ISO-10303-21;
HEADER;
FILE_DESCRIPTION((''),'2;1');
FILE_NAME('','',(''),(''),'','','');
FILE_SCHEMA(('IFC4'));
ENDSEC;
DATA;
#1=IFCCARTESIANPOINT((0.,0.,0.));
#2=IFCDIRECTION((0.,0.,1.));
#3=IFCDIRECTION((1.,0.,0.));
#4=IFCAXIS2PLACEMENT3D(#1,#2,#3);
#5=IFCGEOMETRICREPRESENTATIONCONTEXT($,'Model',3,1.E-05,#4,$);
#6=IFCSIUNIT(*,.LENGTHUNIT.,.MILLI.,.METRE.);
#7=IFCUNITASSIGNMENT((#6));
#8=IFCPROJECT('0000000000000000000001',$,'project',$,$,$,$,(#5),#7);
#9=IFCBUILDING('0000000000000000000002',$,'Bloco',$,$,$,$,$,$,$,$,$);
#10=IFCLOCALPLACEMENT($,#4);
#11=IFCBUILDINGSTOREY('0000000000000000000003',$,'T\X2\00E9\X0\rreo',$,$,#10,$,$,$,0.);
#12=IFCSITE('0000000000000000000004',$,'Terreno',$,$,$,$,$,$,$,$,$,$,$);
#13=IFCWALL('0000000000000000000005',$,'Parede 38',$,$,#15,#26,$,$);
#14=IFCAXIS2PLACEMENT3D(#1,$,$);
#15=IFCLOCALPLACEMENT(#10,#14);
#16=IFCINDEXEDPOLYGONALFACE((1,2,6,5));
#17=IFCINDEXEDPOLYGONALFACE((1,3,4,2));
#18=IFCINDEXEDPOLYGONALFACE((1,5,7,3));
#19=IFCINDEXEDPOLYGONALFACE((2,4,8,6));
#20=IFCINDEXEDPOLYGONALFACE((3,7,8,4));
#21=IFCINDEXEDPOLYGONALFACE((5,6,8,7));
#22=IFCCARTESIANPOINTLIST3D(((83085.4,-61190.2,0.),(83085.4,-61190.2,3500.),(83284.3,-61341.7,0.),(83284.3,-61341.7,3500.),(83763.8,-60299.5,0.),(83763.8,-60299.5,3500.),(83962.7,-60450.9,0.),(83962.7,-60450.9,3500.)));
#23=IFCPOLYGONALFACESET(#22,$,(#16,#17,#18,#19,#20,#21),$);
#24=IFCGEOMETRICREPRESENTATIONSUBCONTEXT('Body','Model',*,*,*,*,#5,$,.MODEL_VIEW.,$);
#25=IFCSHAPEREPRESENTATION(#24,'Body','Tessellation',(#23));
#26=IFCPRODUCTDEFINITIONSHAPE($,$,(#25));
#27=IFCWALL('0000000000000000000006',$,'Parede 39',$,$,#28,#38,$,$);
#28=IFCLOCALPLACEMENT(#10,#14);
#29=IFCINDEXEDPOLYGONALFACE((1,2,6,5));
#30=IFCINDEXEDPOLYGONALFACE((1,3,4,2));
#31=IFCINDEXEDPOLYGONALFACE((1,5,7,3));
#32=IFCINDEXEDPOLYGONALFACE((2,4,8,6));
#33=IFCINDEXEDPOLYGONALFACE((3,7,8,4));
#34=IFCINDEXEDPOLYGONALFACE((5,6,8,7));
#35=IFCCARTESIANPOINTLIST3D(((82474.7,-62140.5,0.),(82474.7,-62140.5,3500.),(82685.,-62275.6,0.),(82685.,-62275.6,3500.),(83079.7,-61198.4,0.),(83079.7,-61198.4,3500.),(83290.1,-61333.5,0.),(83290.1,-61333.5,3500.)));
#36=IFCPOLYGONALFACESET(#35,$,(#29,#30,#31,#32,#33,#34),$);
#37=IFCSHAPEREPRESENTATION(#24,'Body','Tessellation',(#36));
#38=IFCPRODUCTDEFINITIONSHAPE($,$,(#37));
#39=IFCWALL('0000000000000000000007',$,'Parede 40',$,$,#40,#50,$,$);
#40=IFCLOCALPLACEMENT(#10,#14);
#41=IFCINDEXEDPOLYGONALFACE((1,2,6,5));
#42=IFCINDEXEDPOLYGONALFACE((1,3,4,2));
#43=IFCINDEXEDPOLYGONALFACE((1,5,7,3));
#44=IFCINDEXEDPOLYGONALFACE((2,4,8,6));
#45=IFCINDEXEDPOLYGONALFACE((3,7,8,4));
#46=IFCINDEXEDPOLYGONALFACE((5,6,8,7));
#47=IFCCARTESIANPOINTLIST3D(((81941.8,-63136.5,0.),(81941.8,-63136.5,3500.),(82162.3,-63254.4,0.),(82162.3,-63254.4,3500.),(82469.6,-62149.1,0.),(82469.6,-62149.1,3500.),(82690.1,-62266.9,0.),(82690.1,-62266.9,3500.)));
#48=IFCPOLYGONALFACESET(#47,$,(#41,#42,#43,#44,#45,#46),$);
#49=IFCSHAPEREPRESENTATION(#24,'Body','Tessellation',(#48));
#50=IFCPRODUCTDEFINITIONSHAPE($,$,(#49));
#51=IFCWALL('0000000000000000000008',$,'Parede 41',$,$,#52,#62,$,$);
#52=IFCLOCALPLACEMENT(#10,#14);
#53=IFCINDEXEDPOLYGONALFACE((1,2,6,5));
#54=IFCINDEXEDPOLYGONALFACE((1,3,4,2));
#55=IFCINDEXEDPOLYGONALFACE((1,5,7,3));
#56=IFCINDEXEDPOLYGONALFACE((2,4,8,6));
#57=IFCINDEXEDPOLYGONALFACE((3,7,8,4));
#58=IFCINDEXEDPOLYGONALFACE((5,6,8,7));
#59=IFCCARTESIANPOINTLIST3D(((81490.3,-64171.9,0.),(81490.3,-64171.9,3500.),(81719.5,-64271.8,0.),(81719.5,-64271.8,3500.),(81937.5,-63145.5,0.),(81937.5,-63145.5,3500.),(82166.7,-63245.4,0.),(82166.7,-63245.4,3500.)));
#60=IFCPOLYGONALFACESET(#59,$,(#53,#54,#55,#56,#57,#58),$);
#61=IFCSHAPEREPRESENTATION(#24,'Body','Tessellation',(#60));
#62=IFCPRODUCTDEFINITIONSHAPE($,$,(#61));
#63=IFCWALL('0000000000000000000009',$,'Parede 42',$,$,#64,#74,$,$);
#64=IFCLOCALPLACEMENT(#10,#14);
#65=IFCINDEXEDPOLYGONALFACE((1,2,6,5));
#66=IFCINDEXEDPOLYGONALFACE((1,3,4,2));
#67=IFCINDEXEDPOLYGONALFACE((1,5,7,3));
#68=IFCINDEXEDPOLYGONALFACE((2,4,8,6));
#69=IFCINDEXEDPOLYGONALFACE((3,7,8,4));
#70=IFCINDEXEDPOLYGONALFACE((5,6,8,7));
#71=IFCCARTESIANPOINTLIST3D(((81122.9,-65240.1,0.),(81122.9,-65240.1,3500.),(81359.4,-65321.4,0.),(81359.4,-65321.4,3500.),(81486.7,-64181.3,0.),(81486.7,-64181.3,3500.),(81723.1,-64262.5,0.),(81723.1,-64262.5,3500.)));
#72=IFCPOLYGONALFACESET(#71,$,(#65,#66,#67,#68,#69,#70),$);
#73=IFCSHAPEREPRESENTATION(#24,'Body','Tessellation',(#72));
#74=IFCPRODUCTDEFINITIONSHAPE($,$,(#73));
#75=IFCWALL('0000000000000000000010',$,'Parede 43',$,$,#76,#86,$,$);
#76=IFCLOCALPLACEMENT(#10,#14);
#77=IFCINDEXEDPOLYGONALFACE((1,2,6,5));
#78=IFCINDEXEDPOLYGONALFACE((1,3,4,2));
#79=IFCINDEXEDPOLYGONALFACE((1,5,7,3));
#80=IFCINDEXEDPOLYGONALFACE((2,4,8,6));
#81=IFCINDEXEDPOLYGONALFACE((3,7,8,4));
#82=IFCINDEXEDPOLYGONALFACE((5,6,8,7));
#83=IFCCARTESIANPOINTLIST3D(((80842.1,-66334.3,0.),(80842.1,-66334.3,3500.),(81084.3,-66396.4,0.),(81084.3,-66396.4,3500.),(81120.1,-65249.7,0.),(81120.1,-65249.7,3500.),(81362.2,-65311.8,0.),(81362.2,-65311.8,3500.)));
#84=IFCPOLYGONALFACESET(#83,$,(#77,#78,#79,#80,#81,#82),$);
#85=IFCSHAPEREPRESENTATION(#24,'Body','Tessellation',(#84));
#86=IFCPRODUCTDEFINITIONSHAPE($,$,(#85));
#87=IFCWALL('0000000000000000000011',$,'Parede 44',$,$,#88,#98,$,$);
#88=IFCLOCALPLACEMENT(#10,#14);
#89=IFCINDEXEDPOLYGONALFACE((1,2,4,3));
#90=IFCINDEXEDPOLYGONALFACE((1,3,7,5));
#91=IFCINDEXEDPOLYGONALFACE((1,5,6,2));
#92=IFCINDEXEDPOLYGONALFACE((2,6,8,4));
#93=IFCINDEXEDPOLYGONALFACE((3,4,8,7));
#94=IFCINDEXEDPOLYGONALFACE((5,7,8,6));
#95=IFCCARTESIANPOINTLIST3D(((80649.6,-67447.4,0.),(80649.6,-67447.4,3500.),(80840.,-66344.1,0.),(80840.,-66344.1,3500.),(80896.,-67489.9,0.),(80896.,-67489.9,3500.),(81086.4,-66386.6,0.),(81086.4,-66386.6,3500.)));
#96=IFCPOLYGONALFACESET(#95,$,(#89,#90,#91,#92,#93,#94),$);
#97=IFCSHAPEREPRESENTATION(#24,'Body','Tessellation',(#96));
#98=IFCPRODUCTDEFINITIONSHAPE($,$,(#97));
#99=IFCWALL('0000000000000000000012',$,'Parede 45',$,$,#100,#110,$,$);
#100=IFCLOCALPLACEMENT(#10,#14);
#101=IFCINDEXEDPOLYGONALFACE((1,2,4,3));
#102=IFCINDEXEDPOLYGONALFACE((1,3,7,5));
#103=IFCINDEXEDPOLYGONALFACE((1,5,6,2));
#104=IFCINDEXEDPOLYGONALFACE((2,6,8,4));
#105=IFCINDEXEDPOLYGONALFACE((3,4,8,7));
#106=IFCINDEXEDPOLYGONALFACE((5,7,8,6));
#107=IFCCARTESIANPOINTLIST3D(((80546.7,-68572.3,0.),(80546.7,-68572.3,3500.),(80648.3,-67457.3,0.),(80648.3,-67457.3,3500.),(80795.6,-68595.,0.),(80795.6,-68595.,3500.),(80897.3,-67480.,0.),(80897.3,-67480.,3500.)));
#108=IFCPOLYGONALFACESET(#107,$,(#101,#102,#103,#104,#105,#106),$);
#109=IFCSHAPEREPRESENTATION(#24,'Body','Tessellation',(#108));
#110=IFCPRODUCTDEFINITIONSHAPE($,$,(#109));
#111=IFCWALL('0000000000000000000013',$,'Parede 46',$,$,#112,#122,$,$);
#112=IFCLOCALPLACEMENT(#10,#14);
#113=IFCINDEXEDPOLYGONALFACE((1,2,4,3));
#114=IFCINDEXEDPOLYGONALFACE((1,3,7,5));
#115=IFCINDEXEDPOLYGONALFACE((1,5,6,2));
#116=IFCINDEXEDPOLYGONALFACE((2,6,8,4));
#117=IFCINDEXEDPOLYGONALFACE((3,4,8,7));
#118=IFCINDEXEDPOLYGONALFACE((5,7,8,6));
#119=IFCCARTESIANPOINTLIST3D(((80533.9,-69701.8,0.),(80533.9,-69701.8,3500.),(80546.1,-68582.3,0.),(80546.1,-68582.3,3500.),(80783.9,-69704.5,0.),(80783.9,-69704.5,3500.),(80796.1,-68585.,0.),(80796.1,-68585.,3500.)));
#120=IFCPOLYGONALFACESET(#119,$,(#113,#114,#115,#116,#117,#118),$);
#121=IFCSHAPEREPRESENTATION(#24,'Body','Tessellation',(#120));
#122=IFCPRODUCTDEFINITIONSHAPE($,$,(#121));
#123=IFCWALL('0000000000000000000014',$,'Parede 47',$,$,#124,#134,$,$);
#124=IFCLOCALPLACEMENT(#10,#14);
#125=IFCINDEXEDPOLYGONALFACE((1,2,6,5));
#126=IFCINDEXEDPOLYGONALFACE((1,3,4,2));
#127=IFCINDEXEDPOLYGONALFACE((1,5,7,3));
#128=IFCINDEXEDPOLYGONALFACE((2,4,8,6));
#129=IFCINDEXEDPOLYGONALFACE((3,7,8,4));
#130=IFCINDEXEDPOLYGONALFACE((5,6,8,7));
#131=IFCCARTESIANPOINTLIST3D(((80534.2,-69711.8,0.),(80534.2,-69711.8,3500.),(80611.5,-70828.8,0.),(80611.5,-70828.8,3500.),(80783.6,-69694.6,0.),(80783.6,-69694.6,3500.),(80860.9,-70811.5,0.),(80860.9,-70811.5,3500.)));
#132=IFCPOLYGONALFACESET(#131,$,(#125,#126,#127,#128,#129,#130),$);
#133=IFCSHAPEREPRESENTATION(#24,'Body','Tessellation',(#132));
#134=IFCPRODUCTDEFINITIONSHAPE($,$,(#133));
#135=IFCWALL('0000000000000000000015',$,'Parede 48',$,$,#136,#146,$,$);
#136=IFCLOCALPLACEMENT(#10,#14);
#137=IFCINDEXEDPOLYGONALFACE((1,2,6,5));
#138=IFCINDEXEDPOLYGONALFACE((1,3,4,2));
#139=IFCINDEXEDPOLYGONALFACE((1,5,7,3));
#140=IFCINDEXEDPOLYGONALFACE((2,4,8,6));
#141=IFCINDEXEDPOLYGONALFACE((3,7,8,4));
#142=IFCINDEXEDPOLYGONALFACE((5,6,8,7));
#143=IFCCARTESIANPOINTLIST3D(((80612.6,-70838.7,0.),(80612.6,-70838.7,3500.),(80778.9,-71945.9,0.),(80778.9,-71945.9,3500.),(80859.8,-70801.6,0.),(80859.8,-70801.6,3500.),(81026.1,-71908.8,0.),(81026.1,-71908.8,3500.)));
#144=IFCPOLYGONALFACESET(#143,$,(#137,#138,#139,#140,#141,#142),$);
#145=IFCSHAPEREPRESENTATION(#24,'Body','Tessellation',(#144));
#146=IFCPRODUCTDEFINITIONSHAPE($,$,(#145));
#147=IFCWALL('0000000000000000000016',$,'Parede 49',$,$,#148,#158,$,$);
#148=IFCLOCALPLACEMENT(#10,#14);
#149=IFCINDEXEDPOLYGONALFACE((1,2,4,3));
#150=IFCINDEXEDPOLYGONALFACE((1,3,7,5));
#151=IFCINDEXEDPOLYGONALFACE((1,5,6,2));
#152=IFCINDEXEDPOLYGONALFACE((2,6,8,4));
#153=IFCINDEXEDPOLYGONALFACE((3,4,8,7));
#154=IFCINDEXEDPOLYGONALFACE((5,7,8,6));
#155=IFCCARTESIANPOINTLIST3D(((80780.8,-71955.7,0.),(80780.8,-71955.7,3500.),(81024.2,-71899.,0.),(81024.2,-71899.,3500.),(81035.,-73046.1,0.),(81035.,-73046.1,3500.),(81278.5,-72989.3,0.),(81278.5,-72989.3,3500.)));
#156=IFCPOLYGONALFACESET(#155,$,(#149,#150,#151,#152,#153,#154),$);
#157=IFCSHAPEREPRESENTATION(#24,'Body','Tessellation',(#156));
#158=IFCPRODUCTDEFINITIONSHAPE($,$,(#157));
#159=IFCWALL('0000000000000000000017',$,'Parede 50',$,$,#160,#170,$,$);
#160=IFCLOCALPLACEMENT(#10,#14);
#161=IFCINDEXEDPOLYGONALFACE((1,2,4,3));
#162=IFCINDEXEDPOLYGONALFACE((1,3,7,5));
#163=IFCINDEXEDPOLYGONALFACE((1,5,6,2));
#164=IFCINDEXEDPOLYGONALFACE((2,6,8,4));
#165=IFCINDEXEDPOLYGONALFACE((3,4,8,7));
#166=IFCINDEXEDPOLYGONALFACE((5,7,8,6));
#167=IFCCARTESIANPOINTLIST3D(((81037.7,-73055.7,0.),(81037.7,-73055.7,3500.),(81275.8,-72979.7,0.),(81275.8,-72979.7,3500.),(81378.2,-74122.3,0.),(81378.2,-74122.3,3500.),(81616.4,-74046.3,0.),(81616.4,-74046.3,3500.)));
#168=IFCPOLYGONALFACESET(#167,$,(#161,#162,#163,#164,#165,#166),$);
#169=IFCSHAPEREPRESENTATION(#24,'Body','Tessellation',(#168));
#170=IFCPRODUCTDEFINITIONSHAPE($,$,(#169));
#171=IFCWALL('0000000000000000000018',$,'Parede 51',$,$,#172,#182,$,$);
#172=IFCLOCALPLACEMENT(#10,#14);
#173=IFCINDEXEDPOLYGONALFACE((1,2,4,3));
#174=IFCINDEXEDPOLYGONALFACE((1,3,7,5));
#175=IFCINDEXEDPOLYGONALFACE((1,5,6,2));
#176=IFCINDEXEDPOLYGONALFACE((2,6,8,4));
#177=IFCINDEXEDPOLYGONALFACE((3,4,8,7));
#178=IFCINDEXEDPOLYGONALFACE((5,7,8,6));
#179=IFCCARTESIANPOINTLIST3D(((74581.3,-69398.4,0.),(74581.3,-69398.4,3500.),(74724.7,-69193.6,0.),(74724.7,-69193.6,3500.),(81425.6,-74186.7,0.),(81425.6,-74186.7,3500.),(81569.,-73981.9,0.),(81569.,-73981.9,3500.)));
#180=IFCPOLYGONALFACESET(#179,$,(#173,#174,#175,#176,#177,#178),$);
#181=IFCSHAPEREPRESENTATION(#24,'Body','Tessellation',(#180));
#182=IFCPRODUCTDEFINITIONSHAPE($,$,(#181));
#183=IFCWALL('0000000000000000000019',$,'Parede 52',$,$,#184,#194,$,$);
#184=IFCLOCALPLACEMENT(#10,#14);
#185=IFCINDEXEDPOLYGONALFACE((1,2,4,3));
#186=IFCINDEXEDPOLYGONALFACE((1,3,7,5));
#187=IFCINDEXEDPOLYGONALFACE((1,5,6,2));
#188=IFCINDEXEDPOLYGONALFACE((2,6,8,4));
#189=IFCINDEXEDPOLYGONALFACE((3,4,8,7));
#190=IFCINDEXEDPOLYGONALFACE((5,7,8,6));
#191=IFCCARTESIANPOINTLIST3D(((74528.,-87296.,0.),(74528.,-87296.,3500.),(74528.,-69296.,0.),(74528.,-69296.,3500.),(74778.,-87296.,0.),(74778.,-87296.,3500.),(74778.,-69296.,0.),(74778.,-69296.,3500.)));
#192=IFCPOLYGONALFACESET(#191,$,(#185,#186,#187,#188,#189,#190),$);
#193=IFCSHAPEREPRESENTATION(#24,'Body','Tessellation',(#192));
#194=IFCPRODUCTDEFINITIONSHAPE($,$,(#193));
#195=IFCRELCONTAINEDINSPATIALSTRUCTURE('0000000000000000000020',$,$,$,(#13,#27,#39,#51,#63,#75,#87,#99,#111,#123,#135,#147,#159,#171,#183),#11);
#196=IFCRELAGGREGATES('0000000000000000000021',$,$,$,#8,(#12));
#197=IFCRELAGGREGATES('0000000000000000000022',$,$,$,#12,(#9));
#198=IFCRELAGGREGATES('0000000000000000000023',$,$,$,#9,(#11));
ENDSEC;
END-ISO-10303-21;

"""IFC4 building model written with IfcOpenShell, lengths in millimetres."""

from ifc_helpers import new_model, si_unit, origin, origin_with_axes, place, context, subcontext, project, spatial, polyline, outline, extrude, element, save


model = new_model("IFC4")

# Units and contexts
model_context = context("Model", 3, precision=1e-05, world=origin_with_axes())
body_context = subcontext(model_context, "Body", "Model", "MODEL_VIEW")
ifc_project = project(units=[si_unit("LENGTHUNIT", "METRE", prefix="MILLI")], contexts=[model_context])

# Site, building, storey
site = spatial("IfcSite", under=ifc_project, Name="Terreno")
building = spatial("IfcBuilding", under=site, Name="Bloco")
storey_placement = place(None, origin_with_axes())
storey = spatial("IfcBuildingStorey", under=building, at=storey_placement, Name="Térreo", Elevation=0.0)

# Walls
wall_1_placement = place(storey_placement, origin_with_axes())
element("IfcWall", 1, at=wall_1_placement, inside=storey, Name="Parede 38", context=body_context, shape_type="SweptSolid", body=[
    extrude(outline(polyline([(83962.7, -60450.9), (83284.3, -61341.7), (83085.4, -61190.2), (83763.8, -60299.5), (83962.7, -60450.9)])), origin(), (0.0, 0.0, 1.0), 3500.0),
])
wall_2_placement = place(storey_placement, origin_with_axes())
element("IfcWall", 2, at=wall_2_placement, inside=storey, Name="Parede 39", context=body_context, shape_type="SweptSolid", body=[
    extrude(outline(polyline([(83290.1, -61333.5), (82685.0, -62275.6), (82474.7, -62140.5), (83079.7, -61198.4), (83290.1, -61333.5)])), origin(), (0.0, 0.0, 1.0), 3500.0),
])
wall_3_placement = place(storey_placement, origin_with_axes())
element("IfcWall", 3, at=wall_3_placement, inside=storey, Name="Parede 40", context=body_context, shape_type="SweptSolid", body=[
    extrude(outline(polyline([(82690.1, -62266.9), (82162.3, -63254.4), (81941.8, -63136.5), (82469.6, -62149.1), (82690.1, -62266.9)])), origin(), (0.0, 0.0, 1.0), 3500.0),
])
wall_4_placement = place(storey_placement, origin_with_axes())
element("IfcWall", 4, at=wall_4_placement, inside=storey, Name="Parede 41", context=body_context, shape_type="SweptSolid", body=[
    extrude(outline(polyline([(82166.7, -63245.4), (81719.5, -64271.8), (81490.3, -64171.9), (81937.5, -63145.5), (82166.7, -63245.4)])), origin(), (0.0, 0.0, 1.0), 3500.0),
])
wall_5_placement = place(storey_placement, origin_with_axes())
element("IfcWall", 5, at=wall_5_placement, inside=storey, Name="Parede 42", context=body_context, shape_type="SweptSolid", body=[
    extrude(outline(polyline([(81723.1, -64262.5), (81359.4, -65321.4), (81122.9, -65240.1), (81486.7, -64181.3), (81723.1, -64262.5)])), origin(), (0.0, 0.0, 1.0), 3500.0),
])
wall_6_placement = place(storey_placement, origin_with_axes())
element("IfcWall", 6, at=wall_6_placement, inside=storey, Name="Parede 43", context=body_context, shape_type="SweptSolid", body=[
    extrude(outline(polyline([(81362.2, -65311.8), (81084.3, -66396.4), (80842.1, -66334.3), (81120.1, -65249.7), (81362.2, -65311.8)])), origin(), (0.0, 0.0, 1.0), 3500.0),
])
wall_7_placement = place(storey_placement, origin_with_axes())
element("IfcWall", 7, at=wall_7_placement, inside=storey, Name="Parede 44", context=body_context, shape_type="SweptSolid", body=[
    extrude(outline(polyline([(81086.4, -66386.6), (80896.0, -67489.9), (80649.6, -67447.4), (80840.0, -66344.1), (81086.4, -66386.6)])), origin(), (0.0, 0.0, 1.0), 3500.0),
])
wall_8_placement = place(storey_placement, origin_with_axes())
element("IfcWall", 8, at=wall_8_placement, inside=storey, Name="Parede 45", context=body_context, shape_type="SweptSolid", body=[
    extrude(outline(polyline([(80897.3, -67480.0), (80795.6, -68595.0), (80546.7, -68572.3), (80648.3, -67457.3), (80897.3, -67480.0)])), origin(), (0.0, 0.0, 1.0), 3500.0),
])
wall_9_placement = place(storey_placement, origin_with_axes())
element("IfcWall", 9, at=wall_9_placement, inside=storey, Name="Parede 46", context=body_context, shape_type="SweptSolid", body=[
    extrude(outline(polyline([(80796.1, -68585.0), (80783.9, -69704.5), (80533.9, -69701.8), (80546.1, -68582.3), (80796.1, -68585.0)])), origin(), (0.0, 0.0, 1.0), 3500.0),
])
wall_10_placement = place(storey_placement, origin_with_axes())
element("IfcWall", 10, at=wall_10_placement, inside=storey, Name="Parede 47", context=body_context, shape_type="SweptSolid", body=[
    extrude(outline(polyline([(80783.6, -69694.6), (80860.9, -70811.5), (80611.5, -70828.8), (80534.2, -69711.8), (80783.6, -69694.6)])), origin(), (0.0, 0.0, 1.0), 3500.0),
])
wall_11_placement = place(storey_placement, origin_with_axes())
element("IfcWall", 11, at=wall_11_placement, inside=storey, Name="Parede 48", context=body_context, shape_type="SweptSolid", body=[
    extrude(outline(polyline([(80859.8, -70801.6), (81026.1, -71908.8), (80778.9, -71945.9), (80612.6, -70838.7), (80859.8, -70801.6)])), origin(), (0.0, 0.0, 1.0), 3500.0),
])
wall_12_placement = place(storey_placement, origin_with_axes())
element("IfcWall", 12, at=wall_12_placement, inside=storey, Name="Parede 49", context=body_context, shape_type="SweptSolid", body=[
    extrude(outline(polyline([(81024.2, -71899.0), (81278.5, -72989.3), (81035.0, -73046.1), (80780.8, -71955.7), (81024.2, -71899.0)])), origin(), (0.0, 0.0, 1.0), 3500.0),
])
wall_13_placement = place(storey_placement, origin_with_axes())
element("IfcWall", 13, at=wall_13_placement, inside=storey, Name="Parede 50", context=body_context, shape_type="SweptSolid", body=[
    extrude(outline(polyline([(81275.8, -72979.7), (81616.4, -74046.3), (81378.2, -74122.3), (81037.7, -73055.7), (81275.8, -72979.7)])), origin(), (0.0, 0.0, 1.0), 3500.0),
])
wall_14_placement = place(storey_placement, origin_with_axes())
element("IfcWall", 14, at=wall_14_placement, inside=storey, Name="Parede 51", context=body_context, shape_type="SweptSolid", body=[
    extrude(outline(polyline([(81425.6, -74186.7), (74581.3, -69398.4), (74724.7, -69193.6), (81569.0, -73981.9), (81425.6, -74186.7)])), origin(), (0.0, 0.0, 1.0), 3500.0),
])
wall_15_placement = place(storey_placement, origin_with_axes())
element("IfcWall", 15, at=wall_15_placement, inside=storey, Name="Parede 52", context=body_context, shape_type="SweptSolid", body=[
    extrude(outline(polyline([(74778.0, -69296.0), (74778.0, -87296.0), (74528.0, -87296.0), (74528.0, -69296.0), (74778.0, -69296.0)])), origin(), (0.0, 0.0, 1.0), 3500.0),
])

save(model, "model.ifc")
